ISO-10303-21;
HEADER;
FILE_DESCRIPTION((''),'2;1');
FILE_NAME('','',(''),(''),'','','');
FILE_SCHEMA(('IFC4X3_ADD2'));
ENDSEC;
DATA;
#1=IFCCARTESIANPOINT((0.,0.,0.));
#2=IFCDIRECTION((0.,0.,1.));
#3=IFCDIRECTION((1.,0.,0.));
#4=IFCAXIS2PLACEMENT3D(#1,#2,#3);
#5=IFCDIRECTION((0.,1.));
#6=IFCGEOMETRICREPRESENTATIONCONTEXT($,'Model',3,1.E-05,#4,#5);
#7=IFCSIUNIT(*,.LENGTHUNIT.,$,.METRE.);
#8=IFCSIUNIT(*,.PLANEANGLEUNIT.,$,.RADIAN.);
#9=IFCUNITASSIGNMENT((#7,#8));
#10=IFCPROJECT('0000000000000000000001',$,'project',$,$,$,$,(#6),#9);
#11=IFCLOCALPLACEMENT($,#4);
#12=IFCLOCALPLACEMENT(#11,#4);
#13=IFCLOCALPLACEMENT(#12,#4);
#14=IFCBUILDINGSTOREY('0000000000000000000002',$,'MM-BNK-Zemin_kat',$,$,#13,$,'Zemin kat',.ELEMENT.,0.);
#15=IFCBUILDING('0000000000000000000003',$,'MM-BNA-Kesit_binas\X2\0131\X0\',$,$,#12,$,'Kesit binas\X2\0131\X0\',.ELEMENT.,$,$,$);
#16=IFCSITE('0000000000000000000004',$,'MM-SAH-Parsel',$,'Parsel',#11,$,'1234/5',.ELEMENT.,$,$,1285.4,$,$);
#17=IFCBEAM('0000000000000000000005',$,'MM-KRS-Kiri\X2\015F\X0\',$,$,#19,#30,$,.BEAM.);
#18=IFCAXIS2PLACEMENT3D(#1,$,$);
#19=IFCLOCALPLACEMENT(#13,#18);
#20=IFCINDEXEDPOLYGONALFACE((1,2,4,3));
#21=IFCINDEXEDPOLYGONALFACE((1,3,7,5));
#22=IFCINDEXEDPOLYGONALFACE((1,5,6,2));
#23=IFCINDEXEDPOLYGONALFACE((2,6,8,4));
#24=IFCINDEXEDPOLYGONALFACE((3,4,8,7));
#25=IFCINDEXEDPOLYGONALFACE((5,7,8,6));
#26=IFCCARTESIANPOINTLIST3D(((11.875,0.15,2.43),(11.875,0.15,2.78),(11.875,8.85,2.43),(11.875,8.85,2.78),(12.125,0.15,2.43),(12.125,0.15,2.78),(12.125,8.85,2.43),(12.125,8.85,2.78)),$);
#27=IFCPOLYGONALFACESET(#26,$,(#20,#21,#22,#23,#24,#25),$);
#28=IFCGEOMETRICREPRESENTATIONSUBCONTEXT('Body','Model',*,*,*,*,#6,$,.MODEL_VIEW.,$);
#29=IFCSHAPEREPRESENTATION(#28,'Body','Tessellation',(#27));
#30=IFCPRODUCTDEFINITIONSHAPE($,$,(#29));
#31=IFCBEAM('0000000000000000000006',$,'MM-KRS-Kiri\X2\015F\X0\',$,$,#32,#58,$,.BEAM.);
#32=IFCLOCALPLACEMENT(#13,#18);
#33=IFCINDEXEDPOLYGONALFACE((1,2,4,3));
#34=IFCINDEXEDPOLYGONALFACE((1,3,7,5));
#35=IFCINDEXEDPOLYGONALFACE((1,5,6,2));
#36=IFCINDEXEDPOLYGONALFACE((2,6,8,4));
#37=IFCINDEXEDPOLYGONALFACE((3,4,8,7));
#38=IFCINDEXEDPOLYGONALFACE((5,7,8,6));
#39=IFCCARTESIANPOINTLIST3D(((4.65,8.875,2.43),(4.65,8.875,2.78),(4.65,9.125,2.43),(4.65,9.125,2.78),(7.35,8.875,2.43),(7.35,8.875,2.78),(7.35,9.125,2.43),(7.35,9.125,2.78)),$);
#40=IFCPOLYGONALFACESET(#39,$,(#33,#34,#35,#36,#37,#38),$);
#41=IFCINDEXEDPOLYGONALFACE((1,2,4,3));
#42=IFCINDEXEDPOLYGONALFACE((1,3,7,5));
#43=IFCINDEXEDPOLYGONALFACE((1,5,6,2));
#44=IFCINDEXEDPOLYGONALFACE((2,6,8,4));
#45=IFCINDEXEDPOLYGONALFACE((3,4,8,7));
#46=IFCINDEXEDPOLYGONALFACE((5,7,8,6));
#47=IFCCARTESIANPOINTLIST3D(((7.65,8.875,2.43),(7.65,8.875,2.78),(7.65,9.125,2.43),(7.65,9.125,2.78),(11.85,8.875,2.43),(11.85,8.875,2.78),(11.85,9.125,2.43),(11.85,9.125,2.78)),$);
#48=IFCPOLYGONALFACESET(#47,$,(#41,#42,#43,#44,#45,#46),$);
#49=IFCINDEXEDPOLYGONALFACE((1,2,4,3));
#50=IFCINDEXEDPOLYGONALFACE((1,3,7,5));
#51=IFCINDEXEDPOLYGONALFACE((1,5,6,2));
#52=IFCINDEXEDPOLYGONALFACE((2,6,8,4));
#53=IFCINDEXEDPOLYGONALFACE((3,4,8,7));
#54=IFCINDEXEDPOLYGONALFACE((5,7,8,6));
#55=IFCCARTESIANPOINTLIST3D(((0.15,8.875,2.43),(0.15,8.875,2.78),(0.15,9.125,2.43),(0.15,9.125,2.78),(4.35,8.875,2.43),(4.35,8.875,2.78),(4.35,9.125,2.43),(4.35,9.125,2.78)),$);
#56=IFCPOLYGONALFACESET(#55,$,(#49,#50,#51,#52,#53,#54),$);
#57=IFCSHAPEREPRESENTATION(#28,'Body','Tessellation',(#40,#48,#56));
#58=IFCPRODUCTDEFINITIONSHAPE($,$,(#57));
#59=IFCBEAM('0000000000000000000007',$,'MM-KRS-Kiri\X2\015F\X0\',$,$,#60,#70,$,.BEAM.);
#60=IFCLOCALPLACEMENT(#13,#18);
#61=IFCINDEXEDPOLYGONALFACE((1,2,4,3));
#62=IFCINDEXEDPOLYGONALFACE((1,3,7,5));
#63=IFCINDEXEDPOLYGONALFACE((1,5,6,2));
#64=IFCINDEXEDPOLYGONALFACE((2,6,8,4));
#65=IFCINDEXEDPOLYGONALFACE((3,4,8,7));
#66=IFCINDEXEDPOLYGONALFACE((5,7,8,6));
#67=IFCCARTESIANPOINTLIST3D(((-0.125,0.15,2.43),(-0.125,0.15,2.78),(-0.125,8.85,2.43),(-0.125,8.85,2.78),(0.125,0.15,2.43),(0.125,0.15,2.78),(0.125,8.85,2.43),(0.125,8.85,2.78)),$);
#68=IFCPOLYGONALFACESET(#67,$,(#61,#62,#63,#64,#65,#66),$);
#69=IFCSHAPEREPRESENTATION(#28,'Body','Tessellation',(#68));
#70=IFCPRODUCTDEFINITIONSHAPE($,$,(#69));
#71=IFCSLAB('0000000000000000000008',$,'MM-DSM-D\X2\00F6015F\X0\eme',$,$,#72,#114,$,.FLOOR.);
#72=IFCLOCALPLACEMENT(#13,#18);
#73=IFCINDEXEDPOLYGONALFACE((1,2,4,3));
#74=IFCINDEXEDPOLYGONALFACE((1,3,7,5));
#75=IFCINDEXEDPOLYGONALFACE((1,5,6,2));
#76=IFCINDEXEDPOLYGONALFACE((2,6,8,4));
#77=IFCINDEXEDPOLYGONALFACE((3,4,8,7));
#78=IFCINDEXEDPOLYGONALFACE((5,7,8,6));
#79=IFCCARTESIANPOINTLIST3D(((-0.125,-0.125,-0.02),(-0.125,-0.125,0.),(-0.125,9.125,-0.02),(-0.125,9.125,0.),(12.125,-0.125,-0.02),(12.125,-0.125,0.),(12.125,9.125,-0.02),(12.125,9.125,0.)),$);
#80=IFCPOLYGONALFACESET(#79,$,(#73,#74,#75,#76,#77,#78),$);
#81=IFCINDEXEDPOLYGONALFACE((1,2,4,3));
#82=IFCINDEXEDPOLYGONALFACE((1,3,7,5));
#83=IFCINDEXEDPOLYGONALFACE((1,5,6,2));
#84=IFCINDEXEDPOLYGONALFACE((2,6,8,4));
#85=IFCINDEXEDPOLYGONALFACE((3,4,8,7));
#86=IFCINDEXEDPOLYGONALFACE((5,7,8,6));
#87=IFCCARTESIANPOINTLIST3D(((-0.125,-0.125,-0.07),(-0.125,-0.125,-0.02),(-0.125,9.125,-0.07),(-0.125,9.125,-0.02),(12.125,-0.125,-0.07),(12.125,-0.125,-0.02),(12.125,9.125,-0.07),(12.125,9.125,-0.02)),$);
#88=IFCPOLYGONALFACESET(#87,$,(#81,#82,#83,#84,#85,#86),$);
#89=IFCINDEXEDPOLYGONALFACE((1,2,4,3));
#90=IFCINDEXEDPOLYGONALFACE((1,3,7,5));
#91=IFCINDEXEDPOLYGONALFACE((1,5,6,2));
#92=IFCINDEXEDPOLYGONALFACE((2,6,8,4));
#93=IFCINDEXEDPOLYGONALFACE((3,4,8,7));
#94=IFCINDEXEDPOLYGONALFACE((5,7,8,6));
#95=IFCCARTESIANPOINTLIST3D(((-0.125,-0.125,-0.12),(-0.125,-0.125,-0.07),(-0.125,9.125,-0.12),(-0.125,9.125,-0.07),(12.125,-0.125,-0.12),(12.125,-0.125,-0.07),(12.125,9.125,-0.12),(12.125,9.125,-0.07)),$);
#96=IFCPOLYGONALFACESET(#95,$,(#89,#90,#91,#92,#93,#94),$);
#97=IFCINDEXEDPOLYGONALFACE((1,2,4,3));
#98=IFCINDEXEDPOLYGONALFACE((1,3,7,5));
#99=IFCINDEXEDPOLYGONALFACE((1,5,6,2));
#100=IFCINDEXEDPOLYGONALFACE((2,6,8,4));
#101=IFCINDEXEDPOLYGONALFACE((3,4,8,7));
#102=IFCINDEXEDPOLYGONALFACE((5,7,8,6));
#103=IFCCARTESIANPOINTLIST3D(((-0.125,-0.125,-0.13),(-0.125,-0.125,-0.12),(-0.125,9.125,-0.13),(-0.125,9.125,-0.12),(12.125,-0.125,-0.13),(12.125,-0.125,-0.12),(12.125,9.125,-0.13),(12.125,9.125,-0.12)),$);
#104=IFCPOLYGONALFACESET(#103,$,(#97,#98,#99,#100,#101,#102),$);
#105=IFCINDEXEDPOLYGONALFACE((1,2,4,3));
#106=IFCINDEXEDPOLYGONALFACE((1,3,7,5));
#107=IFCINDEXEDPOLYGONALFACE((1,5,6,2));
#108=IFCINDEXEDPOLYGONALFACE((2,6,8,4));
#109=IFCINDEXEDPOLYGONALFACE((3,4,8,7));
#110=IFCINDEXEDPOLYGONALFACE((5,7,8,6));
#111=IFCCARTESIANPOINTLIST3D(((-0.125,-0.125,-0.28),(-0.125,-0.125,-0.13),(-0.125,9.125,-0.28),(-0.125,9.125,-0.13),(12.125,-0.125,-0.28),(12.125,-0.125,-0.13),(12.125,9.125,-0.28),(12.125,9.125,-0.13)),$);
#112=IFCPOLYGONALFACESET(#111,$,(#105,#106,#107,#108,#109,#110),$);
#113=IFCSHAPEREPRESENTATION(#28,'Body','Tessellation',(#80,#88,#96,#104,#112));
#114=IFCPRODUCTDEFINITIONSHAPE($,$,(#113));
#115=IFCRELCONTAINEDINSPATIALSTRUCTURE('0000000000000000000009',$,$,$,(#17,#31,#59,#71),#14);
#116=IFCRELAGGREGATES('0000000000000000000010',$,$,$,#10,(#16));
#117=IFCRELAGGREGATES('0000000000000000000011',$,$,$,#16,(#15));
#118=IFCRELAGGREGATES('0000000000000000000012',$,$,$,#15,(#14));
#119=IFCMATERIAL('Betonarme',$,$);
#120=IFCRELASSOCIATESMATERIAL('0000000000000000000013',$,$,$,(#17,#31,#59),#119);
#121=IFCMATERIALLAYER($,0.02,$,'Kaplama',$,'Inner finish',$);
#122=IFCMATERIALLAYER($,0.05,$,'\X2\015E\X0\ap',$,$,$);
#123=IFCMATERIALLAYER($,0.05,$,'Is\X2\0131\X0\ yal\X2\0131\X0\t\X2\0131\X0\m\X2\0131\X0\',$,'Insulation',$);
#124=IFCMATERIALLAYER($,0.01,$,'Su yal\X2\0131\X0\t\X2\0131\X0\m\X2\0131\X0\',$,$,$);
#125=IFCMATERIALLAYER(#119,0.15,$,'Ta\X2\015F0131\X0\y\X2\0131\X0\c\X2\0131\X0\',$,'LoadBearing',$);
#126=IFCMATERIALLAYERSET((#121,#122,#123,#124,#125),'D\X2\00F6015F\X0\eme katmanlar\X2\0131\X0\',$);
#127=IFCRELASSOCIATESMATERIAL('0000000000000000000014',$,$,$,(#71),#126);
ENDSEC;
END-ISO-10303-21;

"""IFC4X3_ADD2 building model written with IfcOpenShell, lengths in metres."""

from ifc_helpers import new_model, si_unit, direction, frame, origin_with_axes, place, context, subcontext, project, spatial, polyline, outline, extrude, material, layer, layer_set, layer_usage, element, save


model = new_model("IFC4X3_ADD2")

# Units and contexts
model_context = context("Model", 3, precision=1e-05, world=origin_with_axes(), true_north=direction((0.0, 1.0)))
body_context = subcontext(model_context, "Body", "Model", "MODEL_VIEW")
ifc_project = project(units=[si_unit("LENGTHUNIT", "METRE"), si_unit("PLANEANGLEUNIT", "RADIAN")], contexts=[model_context])

# Site, building, storey
site_placement = place(None, origin_with_axes())
site = spatial("IfcSite", under=ifc_project, at=site_placement, Name="MM-SAH-Parsel", ObjectType="Parsel", LongName="1234/5", CompositionType="ELEMENT", RefElevation=1285.4)
building_placement = place(site_placement, origin_with_axes())
building = spatial("IfcBuilding", under=site, at=building_placement, Name="MM-BNA-Kesit_binası", LongName="Kesit binası", CompositionType="ELEMENT")
storey_placement = place(building_placement, origin_with_axes())
storey = spatial("IfcBuildingStorey", under=building, at=storey_placement, Name="MM-BNK-Zemin_kat", LongName="Zemin kat", CompositionType="ELEMENT", Elevation=0.0)

# Shared definitions
ifc_material_1 = material(Name="Betonarme")

# Beams
beam_1_placement = place(storey_placement, origin_with_axes())
element("IfcBeam", 1, at=beam_1_placement, inside=storey, material=ifc_material_1, Name="MM-KRS-Kiriş", PredefinedType="BEAM", context=body_context, shape_type="SweptSolid", body=[
    extrude(outline(polyline([(12.125, 0.15), (12.125, 8.85), (11.875, 8.85), (11.875, 0.15), (12.125, 0.15)])), frame((0.0, 0.0, 2.43)), (0.0, 0.0, 1.0), 0.35),
])
beam_2_placement = place(storey_placement, origin_with_axes())
element("IfcBeam", 2, at=beam_2_placement, inside=storey, material=ifc_material_1, Name="MM-KRS-Kiriş", PredefinedType="BEAM", context=body_context, shape_type="SweptSolid", body=[
    extrude(outline(polyline([(7.35, 9.125), (4.65, 9.125), (4.65, 8.875), (7.35, 8.875), (7.35, 9.125)])), frame((0.0, 0.0, 2.43)), (0.0, 0.0, 1.0), 0.35),
    extrude(outline(polyline([(11.85, 9.125), (7.65, 9.125), (7.65, 8.875), (11.85, 8.875), (11.85, 9.125)])), frame((0.0, 0.0, 2.43)), (0.0, 0.0, 1.0), 0.35),
    extrude(outline(polyline([(4.35, 9.125), (0.15, 9.125), (0.15, 8.875), (4.35, 8.875), (4.35, 9.125)])), frame((0.0, 0.0, 2.43)), (0.0, 0.0, 1.0), 0.35),
])
beam_3_placement = place(storey_placement, origin_with_axes())
element("IfcBeam", 3, at=beam_3_placement, inside=storey, material=ifc_material_1, Name="MM-KRS-Kiriş", PredefinedType="BEAM", context=body_context, shape_type="SweptSolid", body=[
    extrude(outline(polyline([(-0.125, 8.85), (-0.125, 0.15), (0.125, 0.15), (0.125, 8.85), (-0.125, 8.85)])), frame((0.0, 0.0, 2.43)), (0.0, 0.0, 1.0), 0.35),
])

# Slab
ifc_layer_1 = layer(None, 0.02, Name="Kaplama", Category="Inner finish")
ifc_layer_2 = layer(None, 0.05, Name="Şap")
ifc_layer_3 = layer(None, 0.05, Name="Isı yalıtımı", Category="Insulation")
ifc_layer_4 = layer(None, 0.01, Name="Su yalıtımı")
ifc_layer_5 = layer(ifc_material_1, 0.15, Name="Taşıyıcı", Category="LoadBearing")
ifc_layer_set_1 = layer_set([ifc_layer_1, ifc_layer_2, ifc_layer_3, ifc_layer_4, ifc_layer_5], Name="Döşeme katmanları")
ifc_layer_usage = layer_usage(ifc_layer_set_1, "AXIS3", "NEGATIVE", 0.0)
slab_placement = place(storey_placement, origin_with_axes())
element("IfcSlab", 4, at=slab_placement, inside=storey, material=ifc_layer_usage, Name="MM-DSM-Döşeme", PredefinedType="FLOOR", context=body_context, shape_type="SweptSolid", body=[
    extrude(outline(polyline([(-0.125, -0.125), (12.125, -0.125), (12.125, 9.125), (-0.125, 9.125), (-0.125, -0.125)])), frame((0.0, 0.0, -0.02)), (0.0, 0.0, 1.0), 0.02),
    extrude(outline(polyline([(-0.125, -0.125), (12.125, -0.125), (12.125, 9.125), (-0.125, 9.125), (-0.125, -0.125)])), frame((0.0, 0.0, -0.07)), (0.0, 0.0, 1.0), 0.05),
    extrude(outline(polyline([(-0.125, -0.125), (12.125, -0.125), (12.125, 9.125), (-0.125, 9.125), (-0.125, -0.125)])), frame((0.0, 0.0, -0.12)), (0.0, 0.0, 1.0), 0.05),
    extrude(outline(polyline([(-0.125, -0.125), (12.125, -0.125), (12.125, 9.125), (-0.125, 9.125), (-0.125, -0.125)])), frame((0.0, 0.0, -0.13)), (0.0, 0.0, 1.0), 0.01),
    extrude(outline(polyline([(-0.125, -0.125), (12.125, -0.125), (12.125, 9.125), (-0.125, 9.125), (-0.125, -0.125)])), frame((0.0, 0.0, -0.28)), (0.0, 0.0, 1.0), 0.15),
])

save(model, "model.ifc")
